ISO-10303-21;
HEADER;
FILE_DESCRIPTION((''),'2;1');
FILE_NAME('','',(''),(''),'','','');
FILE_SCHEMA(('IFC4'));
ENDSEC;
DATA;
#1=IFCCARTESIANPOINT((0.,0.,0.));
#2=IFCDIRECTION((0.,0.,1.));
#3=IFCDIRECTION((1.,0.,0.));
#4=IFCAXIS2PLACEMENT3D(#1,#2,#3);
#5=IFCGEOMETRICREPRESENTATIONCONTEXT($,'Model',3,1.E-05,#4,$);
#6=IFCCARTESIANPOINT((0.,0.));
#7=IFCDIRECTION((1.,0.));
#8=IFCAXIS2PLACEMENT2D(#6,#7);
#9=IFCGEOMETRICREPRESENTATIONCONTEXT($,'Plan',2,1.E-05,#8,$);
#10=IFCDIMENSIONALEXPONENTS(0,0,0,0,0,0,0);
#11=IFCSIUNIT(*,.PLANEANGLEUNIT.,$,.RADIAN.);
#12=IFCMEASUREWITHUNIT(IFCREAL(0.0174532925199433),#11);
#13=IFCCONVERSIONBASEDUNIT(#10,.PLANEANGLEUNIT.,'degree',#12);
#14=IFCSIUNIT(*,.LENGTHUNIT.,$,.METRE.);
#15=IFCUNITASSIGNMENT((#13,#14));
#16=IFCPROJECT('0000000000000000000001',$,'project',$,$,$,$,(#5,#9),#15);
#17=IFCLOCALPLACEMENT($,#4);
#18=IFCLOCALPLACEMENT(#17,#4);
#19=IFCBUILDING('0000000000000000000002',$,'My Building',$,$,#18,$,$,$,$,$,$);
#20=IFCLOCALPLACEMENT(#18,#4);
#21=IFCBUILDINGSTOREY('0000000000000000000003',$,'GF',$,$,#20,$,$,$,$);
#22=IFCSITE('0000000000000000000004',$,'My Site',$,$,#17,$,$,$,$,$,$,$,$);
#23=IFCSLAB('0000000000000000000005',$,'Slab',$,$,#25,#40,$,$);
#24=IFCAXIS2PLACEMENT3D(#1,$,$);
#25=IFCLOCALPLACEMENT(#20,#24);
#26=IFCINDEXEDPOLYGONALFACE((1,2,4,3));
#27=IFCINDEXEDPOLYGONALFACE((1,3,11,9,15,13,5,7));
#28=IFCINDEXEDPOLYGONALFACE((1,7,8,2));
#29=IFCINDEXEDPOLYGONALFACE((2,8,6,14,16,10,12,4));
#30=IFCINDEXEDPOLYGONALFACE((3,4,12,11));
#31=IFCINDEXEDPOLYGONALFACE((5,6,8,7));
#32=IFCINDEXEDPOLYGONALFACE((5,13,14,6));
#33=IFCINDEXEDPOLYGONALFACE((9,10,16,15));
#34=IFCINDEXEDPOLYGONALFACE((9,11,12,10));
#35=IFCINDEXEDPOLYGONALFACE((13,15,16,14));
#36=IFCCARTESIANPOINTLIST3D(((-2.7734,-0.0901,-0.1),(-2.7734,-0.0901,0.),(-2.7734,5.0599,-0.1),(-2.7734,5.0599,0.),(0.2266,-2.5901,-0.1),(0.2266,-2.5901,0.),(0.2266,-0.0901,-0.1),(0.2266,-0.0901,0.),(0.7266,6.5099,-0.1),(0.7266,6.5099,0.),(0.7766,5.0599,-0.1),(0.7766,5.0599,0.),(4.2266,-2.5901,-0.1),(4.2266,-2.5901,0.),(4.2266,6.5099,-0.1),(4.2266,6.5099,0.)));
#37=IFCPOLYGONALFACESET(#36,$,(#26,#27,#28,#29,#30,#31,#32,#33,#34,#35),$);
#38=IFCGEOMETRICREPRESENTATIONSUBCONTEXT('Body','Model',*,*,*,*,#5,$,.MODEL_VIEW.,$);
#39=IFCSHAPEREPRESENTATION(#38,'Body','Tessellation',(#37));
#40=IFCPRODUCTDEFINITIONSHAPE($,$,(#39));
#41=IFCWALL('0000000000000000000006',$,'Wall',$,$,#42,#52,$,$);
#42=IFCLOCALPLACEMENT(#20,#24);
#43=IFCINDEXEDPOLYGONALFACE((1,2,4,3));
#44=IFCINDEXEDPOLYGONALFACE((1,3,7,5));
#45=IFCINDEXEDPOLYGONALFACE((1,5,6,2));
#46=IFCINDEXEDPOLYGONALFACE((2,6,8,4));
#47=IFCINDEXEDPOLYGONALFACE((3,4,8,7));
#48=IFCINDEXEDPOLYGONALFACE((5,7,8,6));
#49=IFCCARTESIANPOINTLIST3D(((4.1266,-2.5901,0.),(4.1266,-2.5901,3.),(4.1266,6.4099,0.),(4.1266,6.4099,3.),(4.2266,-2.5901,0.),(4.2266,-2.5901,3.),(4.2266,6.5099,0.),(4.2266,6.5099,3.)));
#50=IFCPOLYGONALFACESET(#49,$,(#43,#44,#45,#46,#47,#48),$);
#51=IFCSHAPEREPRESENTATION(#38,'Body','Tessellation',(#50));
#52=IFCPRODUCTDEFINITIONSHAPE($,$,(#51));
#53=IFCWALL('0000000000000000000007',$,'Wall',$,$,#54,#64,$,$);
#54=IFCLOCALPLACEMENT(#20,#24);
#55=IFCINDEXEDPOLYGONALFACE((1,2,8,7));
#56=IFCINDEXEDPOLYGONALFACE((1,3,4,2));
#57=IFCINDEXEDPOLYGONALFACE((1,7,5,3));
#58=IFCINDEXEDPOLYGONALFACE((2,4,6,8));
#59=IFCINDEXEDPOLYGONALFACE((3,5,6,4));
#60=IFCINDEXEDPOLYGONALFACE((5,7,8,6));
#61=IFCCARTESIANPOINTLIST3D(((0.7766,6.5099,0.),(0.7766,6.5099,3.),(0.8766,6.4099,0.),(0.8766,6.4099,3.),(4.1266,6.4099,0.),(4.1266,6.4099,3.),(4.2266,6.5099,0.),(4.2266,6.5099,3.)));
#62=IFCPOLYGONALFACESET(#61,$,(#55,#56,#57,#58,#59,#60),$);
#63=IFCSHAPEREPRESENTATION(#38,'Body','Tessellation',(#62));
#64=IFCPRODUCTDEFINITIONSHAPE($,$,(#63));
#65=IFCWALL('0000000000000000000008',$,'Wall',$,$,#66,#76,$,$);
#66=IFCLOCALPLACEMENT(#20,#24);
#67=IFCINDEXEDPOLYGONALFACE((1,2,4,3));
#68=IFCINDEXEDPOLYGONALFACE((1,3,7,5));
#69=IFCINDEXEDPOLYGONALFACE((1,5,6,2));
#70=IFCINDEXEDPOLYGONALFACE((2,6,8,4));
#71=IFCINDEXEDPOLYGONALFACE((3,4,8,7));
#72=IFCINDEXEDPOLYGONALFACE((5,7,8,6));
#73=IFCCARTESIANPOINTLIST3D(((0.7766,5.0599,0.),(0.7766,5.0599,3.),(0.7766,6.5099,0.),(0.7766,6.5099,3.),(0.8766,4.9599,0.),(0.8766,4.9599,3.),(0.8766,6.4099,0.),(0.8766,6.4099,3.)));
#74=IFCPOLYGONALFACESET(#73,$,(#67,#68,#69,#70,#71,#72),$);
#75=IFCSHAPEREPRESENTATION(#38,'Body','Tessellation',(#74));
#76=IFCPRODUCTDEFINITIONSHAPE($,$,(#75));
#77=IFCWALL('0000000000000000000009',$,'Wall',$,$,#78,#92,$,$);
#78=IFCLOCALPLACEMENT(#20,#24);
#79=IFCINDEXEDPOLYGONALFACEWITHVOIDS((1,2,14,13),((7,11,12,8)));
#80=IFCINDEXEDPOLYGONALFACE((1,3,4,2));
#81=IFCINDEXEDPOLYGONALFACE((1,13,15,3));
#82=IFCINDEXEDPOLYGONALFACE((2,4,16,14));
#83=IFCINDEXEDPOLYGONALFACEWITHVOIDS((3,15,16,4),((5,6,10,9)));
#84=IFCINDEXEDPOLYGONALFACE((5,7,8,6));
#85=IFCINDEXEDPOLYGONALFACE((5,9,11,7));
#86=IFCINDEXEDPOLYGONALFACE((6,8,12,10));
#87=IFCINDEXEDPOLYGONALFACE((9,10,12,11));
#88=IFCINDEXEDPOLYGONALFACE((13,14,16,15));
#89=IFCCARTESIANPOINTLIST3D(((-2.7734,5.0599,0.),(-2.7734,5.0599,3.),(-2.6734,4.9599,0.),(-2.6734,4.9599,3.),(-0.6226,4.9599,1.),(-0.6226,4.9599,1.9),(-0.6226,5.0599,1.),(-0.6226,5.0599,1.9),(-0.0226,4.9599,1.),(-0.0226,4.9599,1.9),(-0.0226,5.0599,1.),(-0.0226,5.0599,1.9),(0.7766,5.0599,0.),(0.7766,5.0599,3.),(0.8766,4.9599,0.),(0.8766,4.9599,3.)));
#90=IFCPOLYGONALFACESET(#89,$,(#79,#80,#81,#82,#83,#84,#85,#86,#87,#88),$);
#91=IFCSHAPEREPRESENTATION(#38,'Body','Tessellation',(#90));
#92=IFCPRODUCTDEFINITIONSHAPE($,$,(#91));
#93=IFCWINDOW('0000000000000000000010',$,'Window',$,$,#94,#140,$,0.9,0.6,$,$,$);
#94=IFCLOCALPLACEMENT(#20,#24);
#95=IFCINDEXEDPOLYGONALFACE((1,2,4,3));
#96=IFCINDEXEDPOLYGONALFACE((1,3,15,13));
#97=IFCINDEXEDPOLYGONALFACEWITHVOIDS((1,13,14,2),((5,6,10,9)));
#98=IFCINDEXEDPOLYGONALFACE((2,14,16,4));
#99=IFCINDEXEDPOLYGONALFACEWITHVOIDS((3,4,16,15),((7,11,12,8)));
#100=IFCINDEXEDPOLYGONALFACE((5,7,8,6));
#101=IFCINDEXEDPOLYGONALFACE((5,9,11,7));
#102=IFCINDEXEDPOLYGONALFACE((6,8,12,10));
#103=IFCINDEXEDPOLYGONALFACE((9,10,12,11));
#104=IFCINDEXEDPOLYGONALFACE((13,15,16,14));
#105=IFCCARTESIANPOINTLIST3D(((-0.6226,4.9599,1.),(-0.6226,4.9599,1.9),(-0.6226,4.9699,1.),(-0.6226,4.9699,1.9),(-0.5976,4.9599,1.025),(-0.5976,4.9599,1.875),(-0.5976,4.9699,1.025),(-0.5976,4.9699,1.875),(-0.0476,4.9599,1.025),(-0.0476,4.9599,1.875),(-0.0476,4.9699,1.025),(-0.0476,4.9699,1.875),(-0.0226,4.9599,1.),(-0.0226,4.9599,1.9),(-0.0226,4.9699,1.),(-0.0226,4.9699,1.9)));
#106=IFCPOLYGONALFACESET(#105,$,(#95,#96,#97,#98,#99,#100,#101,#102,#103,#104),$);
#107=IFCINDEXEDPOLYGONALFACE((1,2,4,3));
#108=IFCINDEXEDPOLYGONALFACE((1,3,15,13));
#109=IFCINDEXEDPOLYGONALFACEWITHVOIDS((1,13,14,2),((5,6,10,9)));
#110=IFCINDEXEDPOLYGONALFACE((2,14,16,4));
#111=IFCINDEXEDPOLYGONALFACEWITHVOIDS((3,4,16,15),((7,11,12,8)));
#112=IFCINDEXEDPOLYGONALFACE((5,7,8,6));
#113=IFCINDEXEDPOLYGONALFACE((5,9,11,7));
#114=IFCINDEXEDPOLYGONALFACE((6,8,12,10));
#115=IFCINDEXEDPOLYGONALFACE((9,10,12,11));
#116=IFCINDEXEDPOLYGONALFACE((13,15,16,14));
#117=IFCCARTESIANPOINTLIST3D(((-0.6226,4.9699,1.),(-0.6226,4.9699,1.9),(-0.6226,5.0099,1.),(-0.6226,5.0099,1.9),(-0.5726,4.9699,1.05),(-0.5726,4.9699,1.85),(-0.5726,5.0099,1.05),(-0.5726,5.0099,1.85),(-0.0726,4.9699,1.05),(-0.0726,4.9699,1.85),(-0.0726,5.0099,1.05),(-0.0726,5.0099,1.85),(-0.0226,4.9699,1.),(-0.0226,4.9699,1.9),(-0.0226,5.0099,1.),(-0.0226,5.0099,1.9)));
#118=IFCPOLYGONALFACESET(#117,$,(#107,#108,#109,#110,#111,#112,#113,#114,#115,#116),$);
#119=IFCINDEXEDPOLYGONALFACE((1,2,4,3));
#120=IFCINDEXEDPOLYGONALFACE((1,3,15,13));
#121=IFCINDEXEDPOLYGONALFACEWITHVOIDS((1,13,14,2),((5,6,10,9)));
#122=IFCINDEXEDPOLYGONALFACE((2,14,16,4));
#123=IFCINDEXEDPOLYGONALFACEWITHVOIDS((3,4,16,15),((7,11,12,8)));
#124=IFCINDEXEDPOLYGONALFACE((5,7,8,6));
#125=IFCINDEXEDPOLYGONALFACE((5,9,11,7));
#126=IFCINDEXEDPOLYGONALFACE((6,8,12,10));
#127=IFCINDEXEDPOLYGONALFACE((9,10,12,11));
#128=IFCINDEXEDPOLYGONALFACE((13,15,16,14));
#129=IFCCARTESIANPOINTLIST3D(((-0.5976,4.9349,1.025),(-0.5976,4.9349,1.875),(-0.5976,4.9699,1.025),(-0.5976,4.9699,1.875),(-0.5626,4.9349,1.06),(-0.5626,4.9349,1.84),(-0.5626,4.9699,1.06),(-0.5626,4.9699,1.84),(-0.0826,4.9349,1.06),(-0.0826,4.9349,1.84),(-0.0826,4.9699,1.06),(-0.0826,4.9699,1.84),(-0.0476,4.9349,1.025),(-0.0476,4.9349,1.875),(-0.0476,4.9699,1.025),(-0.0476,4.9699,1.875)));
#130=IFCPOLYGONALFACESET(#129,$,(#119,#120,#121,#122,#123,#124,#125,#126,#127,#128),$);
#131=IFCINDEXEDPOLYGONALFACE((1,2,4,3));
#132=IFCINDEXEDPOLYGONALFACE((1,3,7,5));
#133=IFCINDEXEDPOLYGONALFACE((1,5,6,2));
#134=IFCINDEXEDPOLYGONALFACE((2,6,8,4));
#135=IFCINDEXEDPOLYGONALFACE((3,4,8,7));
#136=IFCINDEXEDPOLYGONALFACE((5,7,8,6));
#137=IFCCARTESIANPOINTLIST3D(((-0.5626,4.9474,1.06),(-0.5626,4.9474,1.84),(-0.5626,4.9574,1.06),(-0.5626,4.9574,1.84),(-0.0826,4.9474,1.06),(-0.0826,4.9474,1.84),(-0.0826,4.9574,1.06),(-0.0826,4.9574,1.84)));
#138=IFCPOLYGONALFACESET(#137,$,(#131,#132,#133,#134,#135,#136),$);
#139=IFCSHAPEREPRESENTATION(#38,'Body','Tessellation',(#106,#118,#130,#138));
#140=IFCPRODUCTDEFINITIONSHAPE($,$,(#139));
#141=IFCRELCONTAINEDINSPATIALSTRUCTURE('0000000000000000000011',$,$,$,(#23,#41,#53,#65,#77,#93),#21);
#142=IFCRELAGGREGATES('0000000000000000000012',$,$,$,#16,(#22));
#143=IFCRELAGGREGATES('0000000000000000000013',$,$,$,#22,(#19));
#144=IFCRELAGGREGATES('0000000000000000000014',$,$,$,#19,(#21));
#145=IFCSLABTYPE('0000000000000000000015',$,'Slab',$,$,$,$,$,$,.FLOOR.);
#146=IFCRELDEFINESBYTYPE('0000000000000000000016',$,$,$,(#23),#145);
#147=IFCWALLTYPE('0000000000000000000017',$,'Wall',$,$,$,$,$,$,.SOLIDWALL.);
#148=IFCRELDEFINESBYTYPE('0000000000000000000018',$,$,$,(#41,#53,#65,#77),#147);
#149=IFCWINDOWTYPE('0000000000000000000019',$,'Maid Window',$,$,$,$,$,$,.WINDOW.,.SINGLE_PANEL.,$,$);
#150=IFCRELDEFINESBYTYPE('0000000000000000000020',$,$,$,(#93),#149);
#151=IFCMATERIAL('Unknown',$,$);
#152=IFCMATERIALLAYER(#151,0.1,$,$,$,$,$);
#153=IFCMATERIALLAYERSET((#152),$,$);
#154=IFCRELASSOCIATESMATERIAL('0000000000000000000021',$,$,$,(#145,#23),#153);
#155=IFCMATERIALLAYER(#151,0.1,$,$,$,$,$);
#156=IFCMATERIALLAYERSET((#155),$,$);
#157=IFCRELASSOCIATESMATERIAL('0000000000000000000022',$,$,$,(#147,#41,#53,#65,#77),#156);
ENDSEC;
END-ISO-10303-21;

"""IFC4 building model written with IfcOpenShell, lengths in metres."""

from ifc_helpers import new_model, entity, si_unit, converted_unit, frame, origin_with_axes, origin_2d_with_axis, place, context, subcontext, project, spatial, line, indexed_curve, outline, extrude, shape, source, transform, mapped, material, layer, layer_set, layer_usage, type_object, type_shapes, element, fill, save


model = new_model("IFC4")

# Units and contexts
model_context = context("Model", 3, precision=1e-05, world=origin_with_axes())
plan_context = context("Plan", 2, precision=1e-05, world=origin_2d_with_axis())
body_context_1 = subcontext(model_context, "Body", "Model", "MODEL_VIEW")
body_context_2 = subcontext(plan_context, "Body", "Plan", "PLAN_VIEW")
ifc_project = project(units=[converted_unit("PLANEANGLEUNIT", "degree", entity("IfcReal", 0.0174532925199433), si_unit("PLANEANGLEUNIT", "RADIAN"), dimensions=[0, 0, 0, 0, 0, 0, 0]), si_unit("LENGTHUNIT", "METRE")], contexts=[model_context, plan_context])

# Site, building, storey
site_placement = place(None, origin_with_axes())
site = spatial("IfcSite", under=ifc_project, at=site_placement, Name="My Site")
building_placement = place(site_placement, origin_with_axes())
building = spatial("IfcBuilding", under=site, at=building_placement, Name="My Building")
storey_placement = place(building_placement, origin_with_axes())
storey = spatial("IfcBuildingStorey", under=building, at=storey_placement, Name="GF")

# Slab
ifc_material = material(Name="Unknown")
ifc_layer_1 = layer(ifc_material, 0.1)
ifc_layer_set_1 = layer_set([ifc_layer_1])
ifc_layer_usage_1 = layer_usage(ifc_layer_set_1, "AXIS3", "POSITIVE", -0.1)
slab_type = type_object("IfcSlabType", Name="Slab", PredefinedType="FLOOR", material=ifc_layer_set_1)
slab_placement = place(storey_placement, frame((4.2266, -2.5901, 0.0), z_axis=(0.0, 0.0, 1.0), x_axis=(1.0, 0.0, 0.0)))
element("IfcSlab", 1, at=slab_placement, inside=storey, type_object=slab_type, material=ifc_layer_usage_1, Name="Slab", context=body_context_1, shape_type="SweptSolid", body=[
    extrude(outline(indexed_curve([(0.0, 0.0), (0.0, 9.1), (-3.5, 9.1), (-3.45, 7.65), (-7.0, 7.65), (-7.0, 2.5), (-4.0, 2.5), (-4.0, 0.0), (0.0, 0.0)])), frame((0.0, 0.0, -0.1), z_axis=(0.0, 0.0, 1.0), x_axis=(1.0, 0.0, 0.0)), (0.0, 0.0, 1.0), 0.1),
])

# Shared definitions
ifc_layer_2 = layer(ifc_material, 0.1)
ifc_layer_set_2 = layer_set([ifc_layer_2])
wall_type = type_object("IfcWallType", Name="Wall", PredefinedType="SOLIDWALL", material=ifc_layer_set_2)

# Walls
ifc_layer_usage_2 = layer_usage(ifc_layer_set_2, "AXIS2", "POSITIVE", 0.0)
wall_1_placement = place(storey_placement, frame((4.2266, -2.5901, 0.0), z_axis=(0.0, 0.0, 1.0), x_axis=(0.0, 1.0, 0.0)))
element("IfcWall", 2, at=wall_1_placement, inside=storey, type_object=wall_type, material=ifc_layer_usage_2, Name="Wall", context=body_context_1, shape_type="SweptSolid", body=[
    extrude(outline(indexed_curve([(0.0, 0.0), (0.0, 0.1), (9.0, 0.1), (9.1, 0.0)], segments=[line(1, 2, 3, 4, 1)])), origin_with_axes(), (0.0, 0.0, 1.0), 3.0),
])
ifc_layer_usage_3 = layer_usage(ifc_layer_set_2, "AXIS2", "POSITIVE", 0.0)
wall_2_placement = place(storey_placement, frame((4.2266, 6.5099, 0.0), z_axis=(0.0, 0.0, 1.0), x_axis=(-1.0, 0.0, 0.0)))
element("IfcWall", 3, at=wall_2_placement, inside=storey, type_object=wall_type, material=ifc_layer_usage_3, Name="Wall", context=body_context_1, shape_type="SweptSolid", body=[
    extrude(outline(indexed_curve([(0.0, 0.0), (0.1, 0.1), (3.35, 0.1), (3.45, 0.0)], segments=[line(1, 2, 3, 4, 1)])), origin_with_axes(), (0.0, 0.0, 1.0), 3.0),
])
ifc_layer_usage_4 = layer_usage(ifc_layer_set_2, "AXIS2", "POSITIVE", 0.0)
wall_3_placement = place(storey_placement, frame((0.7766, 6.5099, 0.0), z_axis=(0.0, 0.0, 1.0), x_axis=(0.0, -1.0, 0.0)))
element("IfcWall", 4, at=wall_3_placement, inside=storey, type_object=wall_type, material=ifc_layer_usage_4, Name="Wall", context=body_context_1, shape_type="SweptSolid", body=[
    extrude(outline(indexed_curve([(0.0, 0.0), (0.1, 0.1), (1.55, 0.1), (1.45, 0.0)], segments=[line(1, 2, 3, 4, 1)])), origin_with_axes(), (0.0, 0.0, 1.0), 3.0),
])

# Wall, opening, window
ifc_layer_usage_5 = layer_usage(ifc_layer_set_2, "AXIS2", "POSITIVE", 0.0)
wall_4_placement = place(storey_placement, frame((0.7766, 5.0599, 0.0), z_axis=(0.0, 0.0, 1.0), x_axis=(-1.0, 0.0, 0.0)))
wall_4 = element("IfcWall", 5, at=wall_4_placement, inside=storey, type_object=wall_type, material=ifc_layer_usage_5, Name="Wall", context=body_context_1, shape_type="SweptSolid", body=[
    extrude(outline(indexed_curve([(0.0, 0.0), (-0.1, 0.1), (3.45, 0.1), (3.55, 0.0)], segments=[line(1, 2, 3, 4, 1)])), origin_with_axes(), (0.0, 0.0, 1.0), 3.0),
])
shared_shape_1 = source(origin_with_axes(), body_context_1, "Body", "SweptSolid", [
    extrude(outline(indexed_curve([(0.0, 0.0), (0.6, 0.0), (0.6, 0.9), (0.0, 0.9)], segments=[line(1, 2, 3, 4, 1)])), frame((0.0, -0.6, 0.0), z_axis=(0.0, -1.0, 0.0), x_axis=(1.0, 0.0, 0.0)), (0.0, 0.0, -1.0), 1.2),
])
opening_1_placement = place(wall_4_placement, frame((0.7992, 0.0, 1.0), z_axis=(0.0, 0.0, 1.0), x_axis=(1.0, 0.0, 0.0)))
opening_1 = element("IfcOpeningElement", 6, at=opening_1_placement, cuts=wall_4, PredefinedType="OPENING", context=body_context_1, shape_type="MappedRepresentation", body=[
    mapped(shared_shape_1, transform((0.0, 0.0, 0.0), x_axis=(1.0, 0.0, 0.0), y_axis=(0.0, 1.0, 0.0), z_axis=(0.0, 0.0, 1.0), scale=1.0)),
])
window_type_1 = type_object("IfcWindowType", Name="Maid Window", PartitioningType="SINGLE_PANEL", PredefinedType="WINDOW")
shared_shape_2 = source(origin_with_axes(), body_context_1, "Body", "SweptSolid", [
    extrude(outline(indexed_curve([(0.0, 0.0), (0.6, 0.0), (0.6, 0.9), (0.0, 0.9)], segments=[line(1, 2, 3, 4, 1)]), holes=[indexed_curve([(0.025, 0.025), (0.575, 0.025), (0.575, 0.875), (0.025, 0.875)], segments=[line(1, 2, 3, 4, 1)])]), frame((0.0, 0.09, 0.0), z_axis=(0.0, -1.0, 0.0), x_axis=(1.0, 0.0, 0.0)), (0.0, 0.0, -1.0), 0.01),
    extrude(outline(indexed_curve([(0.0, 0.0), (0.6, 0.0), (0.6, 0.9), (0.0, 0.9)], segments=[line(1, 2, 3, 4, 1)]), holes=[indexed_curve([(0.05, 0.05), (0.55, 0.05), (0.55, 0.85), (0.05, 0.85)], segments=[line(1, 2, 3, 4, 1)])]), frame((0.0, 0.05, 0.0), z_axis=(0.0, -1.0, 0.0), x_axis=(1.0, 0.0, 0.0)), (0.0, 0.0, -1.0), 0.04),
    extrude(outline(indexed_curve([(0.0, 0.0), (0.55, 0.0), (0.55, 0.85), (0.0, 0.85)], segments=[line(1, 2, 3, 4, 1)]), holes=[indexed_curve([(0.035, 0.035), (0.515, 0.035), (0.515, 0.815), (0.035, 0.815)], segments=[line(1, 2, 3, 4, 1)])]), frame((0.025, 0.09, 0.025), z_axis=(0.0, -1.0, 0.0), x_axis=(1.0, 0.0, 0.0)), (0.0, 0.0, -1.0), 0.035),
    extrude(outline(indexed_curve([(0.035, 0.035), (0.515, 0.035), (0.515, 0.815), (0.035, 0.815)], segments=[line(1, 2, 3, 4, 1)])), frame((0.025, 0.1025, 0.025), z_axis=(0.0, -1.0, 0.0), x_axis=(1.0, 0.0, 0.0)), (0.0, 0.0, -1.0), 0.01),
])
shared_shape_3 = source(origin_with_axes(), body_context_2, "Body", "Curve2D", [
    entity("IfcIndexedPolyCurve", entity("IfcCartesianPointList2D", [[0.05, 0.05], [0.55, 0.05]])),
    entity("IfcIndexedPolyCurve", entity("IfcCartesianPointList2D", [[0.0, 0.1], [0.025, 0.1], [0.025, 0.09], [0.05, 0.09], [0.05, 0.05], [0.0, 0.05]]), [entity("IfcLineIndex", [1, 2, 3, 4, 5, 6, 1])]),
    entity("IfcIndexedPolyCurve", entity("IfcCartesianPointList2D", [[0.6, 0.1], [0.575, 0.1], [0.575, 0.09], [0.55, 0.09], [0.55, 0.05], [0.6, 0.05]]), [entity("IfcLineIndex", [1, 2, 3, 4, 5, 6, 1])]),
    entity("IfcIndexedPolyCurve", entity("IfcCartesianPointList2D", [[0.025, 0.09], [0.06, 0.09], [0.06, 0.125], [0.025, 0.125]]), [entity("IfcLineIndex", [1, 2, 3, 4, 1])]),
    entity("IfcIndexedPolyCurve", entity("IfcCartesianPointList2D", [[0.575, 0.09], [0.54, 0.09], [0.54, 0.125], [0.575, 0.125]]), [entity("IfcLineIndex", [1, 2, 3, 4, 1])]),
    entity("IfcIndexedPolyCurve", entity("IfcCartesianPointList2D", [[0.06, 0.09], [0.54, 0.09]])),
    entity("IfcIndexedPolyCurve", entity("IfcCartesianPointList2D", [[0.06, 0.125], [0.54, 0.125]])),
    entity("IfcIndexedPolyCurve", entity("IfcCartesianPointList2D", [[0.06, 0.1075], [0.54, 0.1075]])),
])
type_shapes(window_type_1, [shared_shape_2, shared_shape_3])
window_1_placement = place(opening_1_placement, frame((0.0, 0.0, 0.0), z_axis=(0.0, 0.0, 1.0), x_axis=(1.0, 0.0, 0.0)))
window_1 = element("IfcWindow", 7, at=window_1_placement, inside=storey, type_object=window_type_1, Name="Window", OverallHeight=0.9, OverallWidth=0.6, shapes=[
    shape(body_context_1, "Body", "MappedRepresentation", [mapped(shared_shape_2, transform((0.0, 0.0, 0.0), x_axis=(1.0, 0.0, 0.0), y_axis=(0.0, 1.0, 0.0), z_axis=(0.0, 0.0, 1.0), scale=1.0))]),
    shape(body_context_2, "Body", "MappedRepresentation", [mapped(shared_shape_3, transform((0.0, 0.0, 0.0), x_axis=(1.0, 0.0, 0.0), y_axis=(0.0, 1.0, 0.0), z_axis=(0.0, 0.0, 1.0), scale=1.0))]),
])
fill(opening_1, window_1)

save(model, "model.ifc")
